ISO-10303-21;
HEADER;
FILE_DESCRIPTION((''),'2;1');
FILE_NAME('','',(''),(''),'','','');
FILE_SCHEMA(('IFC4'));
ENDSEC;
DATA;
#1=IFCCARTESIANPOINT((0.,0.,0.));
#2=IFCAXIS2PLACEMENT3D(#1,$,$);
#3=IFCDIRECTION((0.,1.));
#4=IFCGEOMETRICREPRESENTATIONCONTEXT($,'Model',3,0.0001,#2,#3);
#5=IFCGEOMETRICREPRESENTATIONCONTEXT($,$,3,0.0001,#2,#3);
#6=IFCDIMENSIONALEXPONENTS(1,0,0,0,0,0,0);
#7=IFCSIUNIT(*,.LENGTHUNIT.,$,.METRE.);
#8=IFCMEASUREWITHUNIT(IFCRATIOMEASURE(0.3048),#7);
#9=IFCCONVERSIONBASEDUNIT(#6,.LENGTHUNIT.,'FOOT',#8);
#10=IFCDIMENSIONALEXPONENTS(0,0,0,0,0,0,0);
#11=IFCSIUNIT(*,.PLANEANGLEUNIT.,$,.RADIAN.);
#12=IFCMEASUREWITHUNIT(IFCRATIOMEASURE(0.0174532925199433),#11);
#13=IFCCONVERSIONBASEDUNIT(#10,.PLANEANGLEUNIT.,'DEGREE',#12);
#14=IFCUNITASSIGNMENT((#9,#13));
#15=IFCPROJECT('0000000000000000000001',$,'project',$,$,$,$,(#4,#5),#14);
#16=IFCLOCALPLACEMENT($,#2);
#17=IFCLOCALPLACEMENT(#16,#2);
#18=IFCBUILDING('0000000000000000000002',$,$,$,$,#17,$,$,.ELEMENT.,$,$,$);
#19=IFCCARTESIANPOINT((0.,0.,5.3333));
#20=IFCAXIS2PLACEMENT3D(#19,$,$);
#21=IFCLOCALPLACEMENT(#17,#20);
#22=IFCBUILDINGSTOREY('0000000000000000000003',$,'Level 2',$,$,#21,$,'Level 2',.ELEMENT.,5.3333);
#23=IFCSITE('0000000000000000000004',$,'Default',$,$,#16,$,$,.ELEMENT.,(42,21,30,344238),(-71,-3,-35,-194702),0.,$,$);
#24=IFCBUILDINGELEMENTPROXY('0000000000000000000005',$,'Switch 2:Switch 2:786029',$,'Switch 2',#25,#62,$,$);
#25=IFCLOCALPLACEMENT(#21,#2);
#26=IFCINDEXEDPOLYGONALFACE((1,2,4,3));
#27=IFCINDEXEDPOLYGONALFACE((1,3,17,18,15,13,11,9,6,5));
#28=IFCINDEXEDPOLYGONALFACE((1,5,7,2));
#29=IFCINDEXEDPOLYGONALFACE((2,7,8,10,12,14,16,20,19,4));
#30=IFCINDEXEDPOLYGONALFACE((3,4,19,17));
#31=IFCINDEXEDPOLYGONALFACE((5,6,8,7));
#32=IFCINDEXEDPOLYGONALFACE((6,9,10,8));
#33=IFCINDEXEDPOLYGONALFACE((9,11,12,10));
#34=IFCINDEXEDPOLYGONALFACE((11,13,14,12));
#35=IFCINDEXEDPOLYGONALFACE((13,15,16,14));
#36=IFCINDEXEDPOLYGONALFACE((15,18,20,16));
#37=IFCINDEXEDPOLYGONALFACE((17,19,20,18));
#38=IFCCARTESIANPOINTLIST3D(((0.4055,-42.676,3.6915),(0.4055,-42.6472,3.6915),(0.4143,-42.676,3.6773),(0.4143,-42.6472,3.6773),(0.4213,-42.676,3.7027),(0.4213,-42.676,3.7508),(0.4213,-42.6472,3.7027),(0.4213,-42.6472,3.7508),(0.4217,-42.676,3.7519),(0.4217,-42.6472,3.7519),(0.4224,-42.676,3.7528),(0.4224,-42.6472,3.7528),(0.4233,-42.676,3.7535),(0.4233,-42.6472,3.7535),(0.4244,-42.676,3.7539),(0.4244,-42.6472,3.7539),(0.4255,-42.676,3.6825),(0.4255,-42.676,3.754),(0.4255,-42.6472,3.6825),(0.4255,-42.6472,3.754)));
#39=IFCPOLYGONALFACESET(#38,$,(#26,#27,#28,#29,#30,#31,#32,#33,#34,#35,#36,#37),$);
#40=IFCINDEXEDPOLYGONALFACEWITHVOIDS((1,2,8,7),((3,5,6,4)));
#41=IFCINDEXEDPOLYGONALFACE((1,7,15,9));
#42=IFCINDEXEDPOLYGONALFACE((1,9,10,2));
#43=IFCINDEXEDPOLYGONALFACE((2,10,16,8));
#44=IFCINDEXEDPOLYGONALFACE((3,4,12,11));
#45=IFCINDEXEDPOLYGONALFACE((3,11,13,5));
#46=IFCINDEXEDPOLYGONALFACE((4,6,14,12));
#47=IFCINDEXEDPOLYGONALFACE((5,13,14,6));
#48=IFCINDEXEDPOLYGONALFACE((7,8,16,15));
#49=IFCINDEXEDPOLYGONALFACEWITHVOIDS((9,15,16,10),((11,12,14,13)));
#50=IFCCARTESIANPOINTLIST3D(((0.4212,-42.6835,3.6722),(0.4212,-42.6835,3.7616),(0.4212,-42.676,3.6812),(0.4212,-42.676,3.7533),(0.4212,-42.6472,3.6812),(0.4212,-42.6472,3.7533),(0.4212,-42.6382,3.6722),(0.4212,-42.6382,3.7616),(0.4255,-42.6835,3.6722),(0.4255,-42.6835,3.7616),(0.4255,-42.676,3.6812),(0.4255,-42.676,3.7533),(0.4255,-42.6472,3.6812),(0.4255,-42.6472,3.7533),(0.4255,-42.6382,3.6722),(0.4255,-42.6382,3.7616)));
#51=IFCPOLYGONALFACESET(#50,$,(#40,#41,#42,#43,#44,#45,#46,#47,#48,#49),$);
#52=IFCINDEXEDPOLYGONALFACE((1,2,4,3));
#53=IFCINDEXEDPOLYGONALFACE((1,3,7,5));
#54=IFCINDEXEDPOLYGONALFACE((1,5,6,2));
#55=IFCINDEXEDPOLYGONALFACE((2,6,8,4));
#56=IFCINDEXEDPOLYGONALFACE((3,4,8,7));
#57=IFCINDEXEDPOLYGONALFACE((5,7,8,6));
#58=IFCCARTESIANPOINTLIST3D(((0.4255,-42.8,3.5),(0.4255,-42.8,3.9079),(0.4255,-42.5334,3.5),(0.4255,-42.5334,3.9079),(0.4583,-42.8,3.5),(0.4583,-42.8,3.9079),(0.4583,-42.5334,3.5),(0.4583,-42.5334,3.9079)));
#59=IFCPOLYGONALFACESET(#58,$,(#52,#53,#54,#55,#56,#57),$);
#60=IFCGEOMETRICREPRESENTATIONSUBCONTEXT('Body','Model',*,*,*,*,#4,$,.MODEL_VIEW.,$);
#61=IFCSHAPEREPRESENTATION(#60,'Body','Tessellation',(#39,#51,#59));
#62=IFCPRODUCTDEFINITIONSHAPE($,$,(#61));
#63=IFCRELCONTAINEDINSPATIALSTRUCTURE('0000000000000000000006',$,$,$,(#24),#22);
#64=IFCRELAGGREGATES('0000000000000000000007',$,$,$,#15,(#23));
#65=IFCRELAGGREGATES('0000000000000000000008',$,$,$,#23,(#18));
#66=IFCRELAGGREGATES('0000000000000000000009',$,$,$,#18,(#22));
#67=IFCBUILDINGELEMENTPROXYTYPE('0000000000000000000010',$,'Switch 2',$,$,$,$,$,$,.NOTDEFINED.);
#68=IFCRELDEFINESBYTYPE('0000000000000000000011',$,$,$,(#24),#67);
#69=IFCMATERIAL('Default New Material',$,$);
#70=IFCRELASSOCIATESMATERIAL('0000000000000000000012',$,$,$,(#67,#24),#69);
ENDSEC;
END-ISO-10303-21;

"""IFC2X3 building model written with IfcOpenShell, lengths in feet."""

from ifc_helpers import new_model, entity, si_unit, converted_unit, direction, frame, frame_2d, origin, origin_2d_with_axis, place, context, subcontext, project, spatial, polyline, circle_curve, parameter, trimmed, segment, composite_curve, rectangle, outline, extrude, source, transform, mapped, material, type_object, type_shapes, element, save


model = new_model("IFC2X3")

# Units and contexts
model_context = context("Model", 3, precision=0.0001, world=origin(), true_north=direction((0.0, 1.0)))
context_of_model = context(None, 3, precision=0.0001, world=origin(), true_north=direction((0.0, 1.0)))
body_context = subcontext(model_context, "Body", "Model", "MODEL_VIEW")
ifc_project = project(units=[converted_unit("LENGTHUNIT", "FOOT", entity("IfcRatioMeasure", 0.3048), si_unit("LENGTHUNIT", "METRE"), dimensions=[1, 0, 0, 0, 0, 0, 0]), converted_unit("PLANEANGLEUNIT", "DEGREE", entity("IfcRatioMeasure", 0.0174532925199433), si_unit("PLANEANGLEUNIT", "RADIAN"), dimensions=[0, 0, 0, 0, 0, 0, 0])], contexts=[model_context, context_of_model])

# Site, building, storey
site_placement = place(None, origin())
site = spatial("IfcSite", under=ifc_project, at=site_placement, Name="Default", CompositionType="ELEMENT", RefLatitude=(42, 21, 30, 344238), RefLongitude=(-71, -3, -35, -194702), RefElevation=0.0)
building_placement = place(site_placement, origin())
building = spatial("IfcBuilding", under=site, at=building_placement, CompositionType="ELEMENT")
storey_placement = place(building_placement, frame((0.0, 0.0, 5.3333)))
storey = spatial("IfcBuildingStorey", under=building, at=storey_placement, Name="Level 2", LongName="Level 2", CompositionType="ELEMENT", Elevation=5.3333)

# Shared definitions
ifc_material_1 = material(Name="Default New Material")

# Building element proxy
building_element_proxy_type_1 = type_object("IfcBuildingElementProxyType", Name="Switch 2", PredefinedType="NOTDEFINED", material=ifc_material_1)
shared_shape_1 = source(origin(), body_context, "Body", "SweptSolid", [
    extrude(outline(composite_curve([segment(polyline([(-0.0252, -0.0211), (-0.0084, -0.0211)]), True, "CONTINUOUS"), segment(polyline([(-0.0084, -0.0211), (-0.0073, -0.0017)]), True, "CONTINUOUS"), segment(polyline([(-0.0073, -0.0017), (0.0336, 0.0237)]), True, "CONTINUOUS"), segment(trimmed(circle_curve(frame_2d((0.0308, 0.0266), x_axis=(0.848706, 0.528865)), 0.004), [parameter(281.689503)], [parameter(4.471238)], True, "PARAMETER"), True, "CONTINUOUS"), segment(polyline([(0.034, 0.029), (-0.0267, -0.0088)]), True, "CONTINUOUS"), segment(polyline([(-0.0267, -0.0088), (-0.0252, -0.0211)]), True, "CONTINUOUS")], self_intersect=False)), frame((-0.0093, 0.0394, 0.2098), z_axis=(1.0, 0.0, 0.0), x_axis=(0.0, 0.528865, 0.848706)), (0.0, 0.0, 1.0), 0.0287),
    extrude(outline(polyline([(-0.0447, -0.0227), (0.0447, -0.0227), (0.0447, 0.0227), (-0.0447, 0.0227), (-0.0447, -0.0227)]), holes=[polyline([(-0.0364, -0.0136), (-0.0364, 0.0151), (0.0357, 0.0151), (0.0357, -0.0136), (-0.0364, -0.0136)])]), frame((0.0058, 0.0329, 0.2169), z_axis=(0.0, 1.0, 0.0), x_axis=(0.0, 0.0, -1.0)), (0.0, 0.0, 1.0), 0.0042),
    extrude(rectangle(XDim=0.0329, YDim=0.2666, at=origin_2d_with_axis()), frame((-0.0001, 0.0164, 0.0), z_axis=(0.0, 0.0, 1.0), x_axis=(0.0, -1.0, 0.0)), (0.0, 0.0, 1.0), 0.4079),
])
type_shapes(building_element_proxy_type_1, [shared_shape_1])
for number, where, z_axis, x_axis, name in (
    (1, (0.4583, -42.6667, 3.5), (0.0, 0.0, 1.0), (0.0, 1.0, 0.0), "Switch 2:Switch 2:786029"),
):
    element("IfcBuildingElementProxy", number, at=place(storey_placement, frame(where, z_axis=z_axis, x_axis=x_axis)), inside=storey, type_object=building_element_proxy_type_1, material=ifc_material_1, Name=name, ObjectType="Switch 2", context=body_context, shape_type="MappedRepresentation", body=[
        mapped(shared_shape_1, transform((0.0, 0.0, 0.0), scale=1.0)),
    ])

save(model, "model.ifc")
